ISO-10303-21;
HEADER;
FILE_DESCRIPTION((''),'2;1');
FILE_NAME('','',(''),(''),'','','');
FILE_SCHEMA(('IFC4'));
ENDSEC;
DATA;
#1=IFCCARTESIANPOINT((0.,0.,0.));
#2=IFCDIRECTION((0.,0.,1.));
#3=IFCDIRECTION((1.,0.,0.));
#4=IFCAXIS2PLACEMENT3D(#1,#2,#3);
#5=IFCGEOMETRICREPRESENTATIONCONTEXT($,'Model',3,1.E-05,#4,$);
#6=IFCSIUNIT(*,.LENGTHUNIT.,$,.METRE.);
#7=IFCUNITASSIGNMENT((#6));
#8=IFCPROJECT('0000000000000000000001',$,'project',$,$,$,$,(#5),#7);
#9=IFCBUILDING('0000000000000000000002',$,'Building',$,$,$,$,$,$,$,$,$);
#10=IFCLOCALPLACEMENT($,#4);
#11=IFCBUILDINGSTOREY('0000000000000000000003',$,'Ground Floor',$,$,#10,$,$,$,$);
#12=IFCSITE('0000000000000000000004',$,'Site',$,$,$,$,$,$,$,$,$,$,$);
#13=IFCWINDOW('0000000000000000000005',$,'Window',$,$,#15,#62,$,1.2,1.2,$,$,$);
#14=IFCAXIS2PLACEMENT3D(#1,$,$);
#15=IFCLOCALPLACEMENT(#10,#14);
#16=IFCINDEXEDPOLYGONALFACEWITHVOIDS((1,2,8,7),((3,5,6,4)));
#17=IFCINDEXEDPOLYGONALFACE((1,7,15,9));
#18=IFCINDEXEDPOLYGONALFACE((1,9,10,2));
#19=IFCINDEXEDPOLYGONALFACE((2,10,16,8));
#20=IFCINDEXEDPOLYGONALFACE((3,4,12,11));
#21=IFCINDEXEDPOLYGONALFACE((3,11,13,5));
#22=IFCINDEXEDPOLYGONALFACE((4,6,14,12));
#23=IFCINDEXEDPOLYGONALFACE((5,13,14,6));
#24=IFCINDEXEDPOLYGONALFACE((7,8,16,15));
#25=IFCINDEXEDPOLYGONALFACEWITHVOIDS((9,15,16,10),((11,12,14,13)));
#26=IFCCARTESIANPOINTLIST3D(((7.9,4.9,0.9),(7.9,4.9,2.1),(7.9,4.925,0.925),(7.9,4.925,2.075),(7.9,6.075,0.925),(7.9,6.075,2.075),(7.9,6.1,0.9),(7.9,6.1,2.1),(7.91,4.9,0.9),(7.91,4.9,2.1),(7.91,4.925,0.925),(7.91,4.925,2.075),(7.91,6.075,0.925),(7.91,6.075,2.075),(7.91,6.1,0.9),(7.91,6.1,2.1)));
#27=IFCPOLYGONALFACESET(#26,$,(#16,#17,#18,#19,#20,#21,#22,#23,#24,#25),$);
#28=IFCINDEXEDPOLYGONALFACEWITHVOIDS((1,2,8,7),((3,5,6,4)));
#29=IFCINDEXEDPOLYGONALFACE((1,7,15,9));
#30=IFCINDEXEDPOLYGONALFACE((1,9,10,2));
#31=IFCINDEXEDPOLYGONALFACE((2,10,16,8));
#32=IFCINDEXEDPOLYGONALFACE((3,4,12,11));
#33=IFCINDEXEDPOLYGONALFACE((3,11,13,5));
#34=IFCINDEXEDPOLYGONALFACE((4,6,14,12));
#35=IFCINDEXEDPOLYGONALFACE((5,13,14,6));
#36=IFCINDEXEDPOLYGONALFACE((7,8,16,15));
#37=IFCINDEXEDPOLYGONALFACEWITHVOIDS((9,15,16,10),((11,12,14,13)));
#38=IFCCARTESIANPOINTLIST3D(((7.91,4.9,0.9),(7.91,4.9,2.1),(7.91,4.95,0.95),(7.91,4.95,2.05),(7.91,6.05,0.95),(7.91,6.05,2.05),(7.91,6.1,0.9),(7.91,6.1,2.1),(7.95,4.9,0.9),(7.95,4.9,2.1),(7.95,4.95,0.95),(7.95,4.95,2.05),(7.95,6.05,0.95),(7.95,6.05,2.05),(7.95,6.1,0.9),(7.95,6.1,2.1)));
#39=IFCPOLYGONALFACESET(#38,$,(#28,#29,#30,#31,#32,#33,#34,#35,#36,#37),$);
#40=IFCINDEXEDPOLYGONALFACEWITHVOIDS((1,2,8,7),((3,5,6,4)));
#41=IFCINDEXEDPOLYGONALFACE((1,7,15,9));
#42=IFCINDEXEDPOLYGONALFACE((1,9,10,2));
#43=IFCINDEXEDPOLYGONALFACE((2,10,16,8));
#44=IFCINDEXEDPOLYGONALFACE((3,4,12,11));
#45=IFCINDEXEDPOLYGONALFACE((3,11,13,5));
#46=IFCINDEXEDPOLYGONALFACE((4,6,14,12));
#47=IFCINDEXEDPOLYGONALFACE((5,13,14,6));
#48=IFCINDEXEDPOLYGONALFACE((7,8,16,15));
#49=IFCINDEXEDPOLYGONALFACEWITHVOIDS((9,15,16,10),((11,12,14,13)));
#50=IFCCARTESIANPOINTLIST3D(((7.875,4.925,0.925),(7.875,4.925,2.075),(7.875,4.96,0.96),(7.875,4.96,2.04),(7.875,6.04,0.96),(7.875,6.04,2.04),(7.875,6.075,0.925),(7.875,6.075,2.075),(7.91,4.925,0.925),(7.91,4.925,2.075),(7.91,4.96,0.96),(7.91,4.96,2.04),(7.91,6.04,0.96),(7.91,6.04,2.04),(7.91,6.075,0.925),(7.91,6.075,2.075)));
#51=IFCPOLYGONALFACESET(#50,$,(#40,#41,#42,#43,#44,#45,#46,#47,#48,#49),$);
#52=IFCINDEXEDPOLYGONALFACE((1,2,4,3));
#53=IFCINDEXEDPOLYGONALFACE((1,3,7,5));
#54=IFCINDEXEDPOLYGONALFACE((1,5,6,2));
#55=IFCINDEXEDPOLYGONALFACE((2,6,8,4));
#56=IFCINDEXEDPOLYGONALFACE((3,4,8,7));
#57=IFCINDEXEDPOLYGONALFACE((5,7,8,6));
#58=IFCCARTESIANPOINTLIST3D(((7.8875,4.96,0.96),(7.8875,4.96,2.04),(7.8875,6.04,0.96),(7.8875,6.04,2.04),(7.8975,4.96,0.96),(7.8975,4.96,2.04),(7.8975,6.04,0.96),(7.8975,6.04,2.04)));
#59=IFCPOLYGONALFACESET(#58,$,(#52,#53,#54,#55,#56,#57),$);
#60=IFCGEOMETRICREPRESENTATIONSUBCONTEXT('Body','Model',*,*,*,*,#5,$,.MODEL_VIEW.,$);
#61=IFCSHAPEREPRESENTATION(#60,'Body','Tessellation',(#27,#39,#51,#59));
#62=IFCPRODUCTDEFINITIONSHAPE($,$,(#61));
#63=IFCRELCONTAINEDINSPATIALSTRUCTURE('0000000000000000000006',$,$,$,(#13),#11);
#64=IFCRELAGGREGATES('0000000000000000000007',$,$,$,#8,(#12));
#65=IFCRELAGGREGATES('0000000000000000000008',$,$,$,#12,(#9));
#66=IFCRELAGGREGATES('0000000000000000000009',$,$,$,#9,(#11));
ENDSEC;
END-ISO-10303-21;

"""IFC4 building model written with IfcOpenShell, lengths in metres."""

from ifc_helpers import new_model, si_unit, frame, origin_with_axes, place, context, subcontext, project, spatial, line, indexed_curve, outline, extrude, element, save


model = new_model("IFC4")

# Units and contexts
model_context = context("Model", 3, precision=1e-05, world=origin_with_axes())
body_context = subcontext(model_context, "Body", "Model", "MODEL_VIEW")
ifc_project = project(units=[si_unit("LENGTHUNIT", "METRE")], contexts=[model_context])

# Site, building, storey
site = spatial("IfcSite", under=ifc_project, Name="Site")
building = spatial("IfcBuilding", under=site, Name="Building")
storey_placement = place(None, origin_with_axes())
storey = spatial("IfcBuildingStorey", under=building, at=storey_placement, Name="Ground Floor")

# Window
for number, where, z_axis, x_axis, name in (
    (1, (8.0, 4.9, 0.9), (0.0, 0.0, 1.0), (0.0, 1.0, 0.0), "Window"),
):
    element("IfcWindow", number, at=place(storey_placement, frame(where, z_axis=z_axis, x_axis=x_axis)), inside=storey, Name=name, OverallHeight=1.2, OverallWidth=1.2, context=body_context, shape_type="SweptSolid", body=[
        extrude(outline(indexed_curve([(0.0, 0.0), (1.2, 0.0), (1.2, 1.2), (0.0, 1.2)], segments=[line(1, 2, 3, 4, 1)]), holes=[indexed_curve([(0.025, 0.025), (1.175, 0.025), (1.175, 1.175), (0.025, 1.175)], segments=[line(1, 2, 3, 4, 1)])]), frame((0.0, 0.09, 0.0), z_axis=(0.0, -1.0, 0.0), x_axis=(1.0, 0.0, 0.0)), (0.0, 0.0, -1.0), 0.01),
        extrude(outline(indexed_curve([(0.0, 0.0), (1.2, 0.0), (1.2, 1.2), (0.0, 1.2)], segments=[line(1, 2, 3, 4, 1)]), holes=[indexed_curve([(0.05, 0.05), (1.15, 0.05), (1.15, 1.15), (0.05, 1.15)], segments=[line(1, 2, 3, 4, 1)])]), frame((0.0, 0.05, 0.0), z_axis=(0.0, -1.0, 0.0), x_axis=(1.0, 0.0, 0.0)), (0.0, 0.0, -1.0), 0.04),
        extrude(outline(indexed_curve([(0.0, 0.0), (1.15, 0.0), (1.15, 1.15), (0.0, 1.15)], segments=[line(1, 2, 3, 4, 1)]), holes=[indexed_curve([(0.035, 0.035), (1.115, 0.035), (1.115, 1.115), (0.035, 1.115)], segments=[line(1, 2, 3, 4, 1)])]), frame((0.025, 0.09, 0.025), z_axis=(0.0, -1.0, 0.0), x_axis=(1.0, 0.0, 0.0)), (0.0, 0.0, -1.0), 0.035),
        extrude(outline(indexed_curve([(0.035, 0.035), (1.115, 0.035), (1.115, 1.115), (0.035, 1.115)], segments=[line(1, 2, 3, 4, 1)])), frame((0.025, 0.1025, 0.025), z_axis=(0.0, -1.0, 0.0), x_axis=(1.0, 0.0, 0.0)), (0.0, 0.0, -1.0), 0.01),
    ])

save(model, "model.ifc")
